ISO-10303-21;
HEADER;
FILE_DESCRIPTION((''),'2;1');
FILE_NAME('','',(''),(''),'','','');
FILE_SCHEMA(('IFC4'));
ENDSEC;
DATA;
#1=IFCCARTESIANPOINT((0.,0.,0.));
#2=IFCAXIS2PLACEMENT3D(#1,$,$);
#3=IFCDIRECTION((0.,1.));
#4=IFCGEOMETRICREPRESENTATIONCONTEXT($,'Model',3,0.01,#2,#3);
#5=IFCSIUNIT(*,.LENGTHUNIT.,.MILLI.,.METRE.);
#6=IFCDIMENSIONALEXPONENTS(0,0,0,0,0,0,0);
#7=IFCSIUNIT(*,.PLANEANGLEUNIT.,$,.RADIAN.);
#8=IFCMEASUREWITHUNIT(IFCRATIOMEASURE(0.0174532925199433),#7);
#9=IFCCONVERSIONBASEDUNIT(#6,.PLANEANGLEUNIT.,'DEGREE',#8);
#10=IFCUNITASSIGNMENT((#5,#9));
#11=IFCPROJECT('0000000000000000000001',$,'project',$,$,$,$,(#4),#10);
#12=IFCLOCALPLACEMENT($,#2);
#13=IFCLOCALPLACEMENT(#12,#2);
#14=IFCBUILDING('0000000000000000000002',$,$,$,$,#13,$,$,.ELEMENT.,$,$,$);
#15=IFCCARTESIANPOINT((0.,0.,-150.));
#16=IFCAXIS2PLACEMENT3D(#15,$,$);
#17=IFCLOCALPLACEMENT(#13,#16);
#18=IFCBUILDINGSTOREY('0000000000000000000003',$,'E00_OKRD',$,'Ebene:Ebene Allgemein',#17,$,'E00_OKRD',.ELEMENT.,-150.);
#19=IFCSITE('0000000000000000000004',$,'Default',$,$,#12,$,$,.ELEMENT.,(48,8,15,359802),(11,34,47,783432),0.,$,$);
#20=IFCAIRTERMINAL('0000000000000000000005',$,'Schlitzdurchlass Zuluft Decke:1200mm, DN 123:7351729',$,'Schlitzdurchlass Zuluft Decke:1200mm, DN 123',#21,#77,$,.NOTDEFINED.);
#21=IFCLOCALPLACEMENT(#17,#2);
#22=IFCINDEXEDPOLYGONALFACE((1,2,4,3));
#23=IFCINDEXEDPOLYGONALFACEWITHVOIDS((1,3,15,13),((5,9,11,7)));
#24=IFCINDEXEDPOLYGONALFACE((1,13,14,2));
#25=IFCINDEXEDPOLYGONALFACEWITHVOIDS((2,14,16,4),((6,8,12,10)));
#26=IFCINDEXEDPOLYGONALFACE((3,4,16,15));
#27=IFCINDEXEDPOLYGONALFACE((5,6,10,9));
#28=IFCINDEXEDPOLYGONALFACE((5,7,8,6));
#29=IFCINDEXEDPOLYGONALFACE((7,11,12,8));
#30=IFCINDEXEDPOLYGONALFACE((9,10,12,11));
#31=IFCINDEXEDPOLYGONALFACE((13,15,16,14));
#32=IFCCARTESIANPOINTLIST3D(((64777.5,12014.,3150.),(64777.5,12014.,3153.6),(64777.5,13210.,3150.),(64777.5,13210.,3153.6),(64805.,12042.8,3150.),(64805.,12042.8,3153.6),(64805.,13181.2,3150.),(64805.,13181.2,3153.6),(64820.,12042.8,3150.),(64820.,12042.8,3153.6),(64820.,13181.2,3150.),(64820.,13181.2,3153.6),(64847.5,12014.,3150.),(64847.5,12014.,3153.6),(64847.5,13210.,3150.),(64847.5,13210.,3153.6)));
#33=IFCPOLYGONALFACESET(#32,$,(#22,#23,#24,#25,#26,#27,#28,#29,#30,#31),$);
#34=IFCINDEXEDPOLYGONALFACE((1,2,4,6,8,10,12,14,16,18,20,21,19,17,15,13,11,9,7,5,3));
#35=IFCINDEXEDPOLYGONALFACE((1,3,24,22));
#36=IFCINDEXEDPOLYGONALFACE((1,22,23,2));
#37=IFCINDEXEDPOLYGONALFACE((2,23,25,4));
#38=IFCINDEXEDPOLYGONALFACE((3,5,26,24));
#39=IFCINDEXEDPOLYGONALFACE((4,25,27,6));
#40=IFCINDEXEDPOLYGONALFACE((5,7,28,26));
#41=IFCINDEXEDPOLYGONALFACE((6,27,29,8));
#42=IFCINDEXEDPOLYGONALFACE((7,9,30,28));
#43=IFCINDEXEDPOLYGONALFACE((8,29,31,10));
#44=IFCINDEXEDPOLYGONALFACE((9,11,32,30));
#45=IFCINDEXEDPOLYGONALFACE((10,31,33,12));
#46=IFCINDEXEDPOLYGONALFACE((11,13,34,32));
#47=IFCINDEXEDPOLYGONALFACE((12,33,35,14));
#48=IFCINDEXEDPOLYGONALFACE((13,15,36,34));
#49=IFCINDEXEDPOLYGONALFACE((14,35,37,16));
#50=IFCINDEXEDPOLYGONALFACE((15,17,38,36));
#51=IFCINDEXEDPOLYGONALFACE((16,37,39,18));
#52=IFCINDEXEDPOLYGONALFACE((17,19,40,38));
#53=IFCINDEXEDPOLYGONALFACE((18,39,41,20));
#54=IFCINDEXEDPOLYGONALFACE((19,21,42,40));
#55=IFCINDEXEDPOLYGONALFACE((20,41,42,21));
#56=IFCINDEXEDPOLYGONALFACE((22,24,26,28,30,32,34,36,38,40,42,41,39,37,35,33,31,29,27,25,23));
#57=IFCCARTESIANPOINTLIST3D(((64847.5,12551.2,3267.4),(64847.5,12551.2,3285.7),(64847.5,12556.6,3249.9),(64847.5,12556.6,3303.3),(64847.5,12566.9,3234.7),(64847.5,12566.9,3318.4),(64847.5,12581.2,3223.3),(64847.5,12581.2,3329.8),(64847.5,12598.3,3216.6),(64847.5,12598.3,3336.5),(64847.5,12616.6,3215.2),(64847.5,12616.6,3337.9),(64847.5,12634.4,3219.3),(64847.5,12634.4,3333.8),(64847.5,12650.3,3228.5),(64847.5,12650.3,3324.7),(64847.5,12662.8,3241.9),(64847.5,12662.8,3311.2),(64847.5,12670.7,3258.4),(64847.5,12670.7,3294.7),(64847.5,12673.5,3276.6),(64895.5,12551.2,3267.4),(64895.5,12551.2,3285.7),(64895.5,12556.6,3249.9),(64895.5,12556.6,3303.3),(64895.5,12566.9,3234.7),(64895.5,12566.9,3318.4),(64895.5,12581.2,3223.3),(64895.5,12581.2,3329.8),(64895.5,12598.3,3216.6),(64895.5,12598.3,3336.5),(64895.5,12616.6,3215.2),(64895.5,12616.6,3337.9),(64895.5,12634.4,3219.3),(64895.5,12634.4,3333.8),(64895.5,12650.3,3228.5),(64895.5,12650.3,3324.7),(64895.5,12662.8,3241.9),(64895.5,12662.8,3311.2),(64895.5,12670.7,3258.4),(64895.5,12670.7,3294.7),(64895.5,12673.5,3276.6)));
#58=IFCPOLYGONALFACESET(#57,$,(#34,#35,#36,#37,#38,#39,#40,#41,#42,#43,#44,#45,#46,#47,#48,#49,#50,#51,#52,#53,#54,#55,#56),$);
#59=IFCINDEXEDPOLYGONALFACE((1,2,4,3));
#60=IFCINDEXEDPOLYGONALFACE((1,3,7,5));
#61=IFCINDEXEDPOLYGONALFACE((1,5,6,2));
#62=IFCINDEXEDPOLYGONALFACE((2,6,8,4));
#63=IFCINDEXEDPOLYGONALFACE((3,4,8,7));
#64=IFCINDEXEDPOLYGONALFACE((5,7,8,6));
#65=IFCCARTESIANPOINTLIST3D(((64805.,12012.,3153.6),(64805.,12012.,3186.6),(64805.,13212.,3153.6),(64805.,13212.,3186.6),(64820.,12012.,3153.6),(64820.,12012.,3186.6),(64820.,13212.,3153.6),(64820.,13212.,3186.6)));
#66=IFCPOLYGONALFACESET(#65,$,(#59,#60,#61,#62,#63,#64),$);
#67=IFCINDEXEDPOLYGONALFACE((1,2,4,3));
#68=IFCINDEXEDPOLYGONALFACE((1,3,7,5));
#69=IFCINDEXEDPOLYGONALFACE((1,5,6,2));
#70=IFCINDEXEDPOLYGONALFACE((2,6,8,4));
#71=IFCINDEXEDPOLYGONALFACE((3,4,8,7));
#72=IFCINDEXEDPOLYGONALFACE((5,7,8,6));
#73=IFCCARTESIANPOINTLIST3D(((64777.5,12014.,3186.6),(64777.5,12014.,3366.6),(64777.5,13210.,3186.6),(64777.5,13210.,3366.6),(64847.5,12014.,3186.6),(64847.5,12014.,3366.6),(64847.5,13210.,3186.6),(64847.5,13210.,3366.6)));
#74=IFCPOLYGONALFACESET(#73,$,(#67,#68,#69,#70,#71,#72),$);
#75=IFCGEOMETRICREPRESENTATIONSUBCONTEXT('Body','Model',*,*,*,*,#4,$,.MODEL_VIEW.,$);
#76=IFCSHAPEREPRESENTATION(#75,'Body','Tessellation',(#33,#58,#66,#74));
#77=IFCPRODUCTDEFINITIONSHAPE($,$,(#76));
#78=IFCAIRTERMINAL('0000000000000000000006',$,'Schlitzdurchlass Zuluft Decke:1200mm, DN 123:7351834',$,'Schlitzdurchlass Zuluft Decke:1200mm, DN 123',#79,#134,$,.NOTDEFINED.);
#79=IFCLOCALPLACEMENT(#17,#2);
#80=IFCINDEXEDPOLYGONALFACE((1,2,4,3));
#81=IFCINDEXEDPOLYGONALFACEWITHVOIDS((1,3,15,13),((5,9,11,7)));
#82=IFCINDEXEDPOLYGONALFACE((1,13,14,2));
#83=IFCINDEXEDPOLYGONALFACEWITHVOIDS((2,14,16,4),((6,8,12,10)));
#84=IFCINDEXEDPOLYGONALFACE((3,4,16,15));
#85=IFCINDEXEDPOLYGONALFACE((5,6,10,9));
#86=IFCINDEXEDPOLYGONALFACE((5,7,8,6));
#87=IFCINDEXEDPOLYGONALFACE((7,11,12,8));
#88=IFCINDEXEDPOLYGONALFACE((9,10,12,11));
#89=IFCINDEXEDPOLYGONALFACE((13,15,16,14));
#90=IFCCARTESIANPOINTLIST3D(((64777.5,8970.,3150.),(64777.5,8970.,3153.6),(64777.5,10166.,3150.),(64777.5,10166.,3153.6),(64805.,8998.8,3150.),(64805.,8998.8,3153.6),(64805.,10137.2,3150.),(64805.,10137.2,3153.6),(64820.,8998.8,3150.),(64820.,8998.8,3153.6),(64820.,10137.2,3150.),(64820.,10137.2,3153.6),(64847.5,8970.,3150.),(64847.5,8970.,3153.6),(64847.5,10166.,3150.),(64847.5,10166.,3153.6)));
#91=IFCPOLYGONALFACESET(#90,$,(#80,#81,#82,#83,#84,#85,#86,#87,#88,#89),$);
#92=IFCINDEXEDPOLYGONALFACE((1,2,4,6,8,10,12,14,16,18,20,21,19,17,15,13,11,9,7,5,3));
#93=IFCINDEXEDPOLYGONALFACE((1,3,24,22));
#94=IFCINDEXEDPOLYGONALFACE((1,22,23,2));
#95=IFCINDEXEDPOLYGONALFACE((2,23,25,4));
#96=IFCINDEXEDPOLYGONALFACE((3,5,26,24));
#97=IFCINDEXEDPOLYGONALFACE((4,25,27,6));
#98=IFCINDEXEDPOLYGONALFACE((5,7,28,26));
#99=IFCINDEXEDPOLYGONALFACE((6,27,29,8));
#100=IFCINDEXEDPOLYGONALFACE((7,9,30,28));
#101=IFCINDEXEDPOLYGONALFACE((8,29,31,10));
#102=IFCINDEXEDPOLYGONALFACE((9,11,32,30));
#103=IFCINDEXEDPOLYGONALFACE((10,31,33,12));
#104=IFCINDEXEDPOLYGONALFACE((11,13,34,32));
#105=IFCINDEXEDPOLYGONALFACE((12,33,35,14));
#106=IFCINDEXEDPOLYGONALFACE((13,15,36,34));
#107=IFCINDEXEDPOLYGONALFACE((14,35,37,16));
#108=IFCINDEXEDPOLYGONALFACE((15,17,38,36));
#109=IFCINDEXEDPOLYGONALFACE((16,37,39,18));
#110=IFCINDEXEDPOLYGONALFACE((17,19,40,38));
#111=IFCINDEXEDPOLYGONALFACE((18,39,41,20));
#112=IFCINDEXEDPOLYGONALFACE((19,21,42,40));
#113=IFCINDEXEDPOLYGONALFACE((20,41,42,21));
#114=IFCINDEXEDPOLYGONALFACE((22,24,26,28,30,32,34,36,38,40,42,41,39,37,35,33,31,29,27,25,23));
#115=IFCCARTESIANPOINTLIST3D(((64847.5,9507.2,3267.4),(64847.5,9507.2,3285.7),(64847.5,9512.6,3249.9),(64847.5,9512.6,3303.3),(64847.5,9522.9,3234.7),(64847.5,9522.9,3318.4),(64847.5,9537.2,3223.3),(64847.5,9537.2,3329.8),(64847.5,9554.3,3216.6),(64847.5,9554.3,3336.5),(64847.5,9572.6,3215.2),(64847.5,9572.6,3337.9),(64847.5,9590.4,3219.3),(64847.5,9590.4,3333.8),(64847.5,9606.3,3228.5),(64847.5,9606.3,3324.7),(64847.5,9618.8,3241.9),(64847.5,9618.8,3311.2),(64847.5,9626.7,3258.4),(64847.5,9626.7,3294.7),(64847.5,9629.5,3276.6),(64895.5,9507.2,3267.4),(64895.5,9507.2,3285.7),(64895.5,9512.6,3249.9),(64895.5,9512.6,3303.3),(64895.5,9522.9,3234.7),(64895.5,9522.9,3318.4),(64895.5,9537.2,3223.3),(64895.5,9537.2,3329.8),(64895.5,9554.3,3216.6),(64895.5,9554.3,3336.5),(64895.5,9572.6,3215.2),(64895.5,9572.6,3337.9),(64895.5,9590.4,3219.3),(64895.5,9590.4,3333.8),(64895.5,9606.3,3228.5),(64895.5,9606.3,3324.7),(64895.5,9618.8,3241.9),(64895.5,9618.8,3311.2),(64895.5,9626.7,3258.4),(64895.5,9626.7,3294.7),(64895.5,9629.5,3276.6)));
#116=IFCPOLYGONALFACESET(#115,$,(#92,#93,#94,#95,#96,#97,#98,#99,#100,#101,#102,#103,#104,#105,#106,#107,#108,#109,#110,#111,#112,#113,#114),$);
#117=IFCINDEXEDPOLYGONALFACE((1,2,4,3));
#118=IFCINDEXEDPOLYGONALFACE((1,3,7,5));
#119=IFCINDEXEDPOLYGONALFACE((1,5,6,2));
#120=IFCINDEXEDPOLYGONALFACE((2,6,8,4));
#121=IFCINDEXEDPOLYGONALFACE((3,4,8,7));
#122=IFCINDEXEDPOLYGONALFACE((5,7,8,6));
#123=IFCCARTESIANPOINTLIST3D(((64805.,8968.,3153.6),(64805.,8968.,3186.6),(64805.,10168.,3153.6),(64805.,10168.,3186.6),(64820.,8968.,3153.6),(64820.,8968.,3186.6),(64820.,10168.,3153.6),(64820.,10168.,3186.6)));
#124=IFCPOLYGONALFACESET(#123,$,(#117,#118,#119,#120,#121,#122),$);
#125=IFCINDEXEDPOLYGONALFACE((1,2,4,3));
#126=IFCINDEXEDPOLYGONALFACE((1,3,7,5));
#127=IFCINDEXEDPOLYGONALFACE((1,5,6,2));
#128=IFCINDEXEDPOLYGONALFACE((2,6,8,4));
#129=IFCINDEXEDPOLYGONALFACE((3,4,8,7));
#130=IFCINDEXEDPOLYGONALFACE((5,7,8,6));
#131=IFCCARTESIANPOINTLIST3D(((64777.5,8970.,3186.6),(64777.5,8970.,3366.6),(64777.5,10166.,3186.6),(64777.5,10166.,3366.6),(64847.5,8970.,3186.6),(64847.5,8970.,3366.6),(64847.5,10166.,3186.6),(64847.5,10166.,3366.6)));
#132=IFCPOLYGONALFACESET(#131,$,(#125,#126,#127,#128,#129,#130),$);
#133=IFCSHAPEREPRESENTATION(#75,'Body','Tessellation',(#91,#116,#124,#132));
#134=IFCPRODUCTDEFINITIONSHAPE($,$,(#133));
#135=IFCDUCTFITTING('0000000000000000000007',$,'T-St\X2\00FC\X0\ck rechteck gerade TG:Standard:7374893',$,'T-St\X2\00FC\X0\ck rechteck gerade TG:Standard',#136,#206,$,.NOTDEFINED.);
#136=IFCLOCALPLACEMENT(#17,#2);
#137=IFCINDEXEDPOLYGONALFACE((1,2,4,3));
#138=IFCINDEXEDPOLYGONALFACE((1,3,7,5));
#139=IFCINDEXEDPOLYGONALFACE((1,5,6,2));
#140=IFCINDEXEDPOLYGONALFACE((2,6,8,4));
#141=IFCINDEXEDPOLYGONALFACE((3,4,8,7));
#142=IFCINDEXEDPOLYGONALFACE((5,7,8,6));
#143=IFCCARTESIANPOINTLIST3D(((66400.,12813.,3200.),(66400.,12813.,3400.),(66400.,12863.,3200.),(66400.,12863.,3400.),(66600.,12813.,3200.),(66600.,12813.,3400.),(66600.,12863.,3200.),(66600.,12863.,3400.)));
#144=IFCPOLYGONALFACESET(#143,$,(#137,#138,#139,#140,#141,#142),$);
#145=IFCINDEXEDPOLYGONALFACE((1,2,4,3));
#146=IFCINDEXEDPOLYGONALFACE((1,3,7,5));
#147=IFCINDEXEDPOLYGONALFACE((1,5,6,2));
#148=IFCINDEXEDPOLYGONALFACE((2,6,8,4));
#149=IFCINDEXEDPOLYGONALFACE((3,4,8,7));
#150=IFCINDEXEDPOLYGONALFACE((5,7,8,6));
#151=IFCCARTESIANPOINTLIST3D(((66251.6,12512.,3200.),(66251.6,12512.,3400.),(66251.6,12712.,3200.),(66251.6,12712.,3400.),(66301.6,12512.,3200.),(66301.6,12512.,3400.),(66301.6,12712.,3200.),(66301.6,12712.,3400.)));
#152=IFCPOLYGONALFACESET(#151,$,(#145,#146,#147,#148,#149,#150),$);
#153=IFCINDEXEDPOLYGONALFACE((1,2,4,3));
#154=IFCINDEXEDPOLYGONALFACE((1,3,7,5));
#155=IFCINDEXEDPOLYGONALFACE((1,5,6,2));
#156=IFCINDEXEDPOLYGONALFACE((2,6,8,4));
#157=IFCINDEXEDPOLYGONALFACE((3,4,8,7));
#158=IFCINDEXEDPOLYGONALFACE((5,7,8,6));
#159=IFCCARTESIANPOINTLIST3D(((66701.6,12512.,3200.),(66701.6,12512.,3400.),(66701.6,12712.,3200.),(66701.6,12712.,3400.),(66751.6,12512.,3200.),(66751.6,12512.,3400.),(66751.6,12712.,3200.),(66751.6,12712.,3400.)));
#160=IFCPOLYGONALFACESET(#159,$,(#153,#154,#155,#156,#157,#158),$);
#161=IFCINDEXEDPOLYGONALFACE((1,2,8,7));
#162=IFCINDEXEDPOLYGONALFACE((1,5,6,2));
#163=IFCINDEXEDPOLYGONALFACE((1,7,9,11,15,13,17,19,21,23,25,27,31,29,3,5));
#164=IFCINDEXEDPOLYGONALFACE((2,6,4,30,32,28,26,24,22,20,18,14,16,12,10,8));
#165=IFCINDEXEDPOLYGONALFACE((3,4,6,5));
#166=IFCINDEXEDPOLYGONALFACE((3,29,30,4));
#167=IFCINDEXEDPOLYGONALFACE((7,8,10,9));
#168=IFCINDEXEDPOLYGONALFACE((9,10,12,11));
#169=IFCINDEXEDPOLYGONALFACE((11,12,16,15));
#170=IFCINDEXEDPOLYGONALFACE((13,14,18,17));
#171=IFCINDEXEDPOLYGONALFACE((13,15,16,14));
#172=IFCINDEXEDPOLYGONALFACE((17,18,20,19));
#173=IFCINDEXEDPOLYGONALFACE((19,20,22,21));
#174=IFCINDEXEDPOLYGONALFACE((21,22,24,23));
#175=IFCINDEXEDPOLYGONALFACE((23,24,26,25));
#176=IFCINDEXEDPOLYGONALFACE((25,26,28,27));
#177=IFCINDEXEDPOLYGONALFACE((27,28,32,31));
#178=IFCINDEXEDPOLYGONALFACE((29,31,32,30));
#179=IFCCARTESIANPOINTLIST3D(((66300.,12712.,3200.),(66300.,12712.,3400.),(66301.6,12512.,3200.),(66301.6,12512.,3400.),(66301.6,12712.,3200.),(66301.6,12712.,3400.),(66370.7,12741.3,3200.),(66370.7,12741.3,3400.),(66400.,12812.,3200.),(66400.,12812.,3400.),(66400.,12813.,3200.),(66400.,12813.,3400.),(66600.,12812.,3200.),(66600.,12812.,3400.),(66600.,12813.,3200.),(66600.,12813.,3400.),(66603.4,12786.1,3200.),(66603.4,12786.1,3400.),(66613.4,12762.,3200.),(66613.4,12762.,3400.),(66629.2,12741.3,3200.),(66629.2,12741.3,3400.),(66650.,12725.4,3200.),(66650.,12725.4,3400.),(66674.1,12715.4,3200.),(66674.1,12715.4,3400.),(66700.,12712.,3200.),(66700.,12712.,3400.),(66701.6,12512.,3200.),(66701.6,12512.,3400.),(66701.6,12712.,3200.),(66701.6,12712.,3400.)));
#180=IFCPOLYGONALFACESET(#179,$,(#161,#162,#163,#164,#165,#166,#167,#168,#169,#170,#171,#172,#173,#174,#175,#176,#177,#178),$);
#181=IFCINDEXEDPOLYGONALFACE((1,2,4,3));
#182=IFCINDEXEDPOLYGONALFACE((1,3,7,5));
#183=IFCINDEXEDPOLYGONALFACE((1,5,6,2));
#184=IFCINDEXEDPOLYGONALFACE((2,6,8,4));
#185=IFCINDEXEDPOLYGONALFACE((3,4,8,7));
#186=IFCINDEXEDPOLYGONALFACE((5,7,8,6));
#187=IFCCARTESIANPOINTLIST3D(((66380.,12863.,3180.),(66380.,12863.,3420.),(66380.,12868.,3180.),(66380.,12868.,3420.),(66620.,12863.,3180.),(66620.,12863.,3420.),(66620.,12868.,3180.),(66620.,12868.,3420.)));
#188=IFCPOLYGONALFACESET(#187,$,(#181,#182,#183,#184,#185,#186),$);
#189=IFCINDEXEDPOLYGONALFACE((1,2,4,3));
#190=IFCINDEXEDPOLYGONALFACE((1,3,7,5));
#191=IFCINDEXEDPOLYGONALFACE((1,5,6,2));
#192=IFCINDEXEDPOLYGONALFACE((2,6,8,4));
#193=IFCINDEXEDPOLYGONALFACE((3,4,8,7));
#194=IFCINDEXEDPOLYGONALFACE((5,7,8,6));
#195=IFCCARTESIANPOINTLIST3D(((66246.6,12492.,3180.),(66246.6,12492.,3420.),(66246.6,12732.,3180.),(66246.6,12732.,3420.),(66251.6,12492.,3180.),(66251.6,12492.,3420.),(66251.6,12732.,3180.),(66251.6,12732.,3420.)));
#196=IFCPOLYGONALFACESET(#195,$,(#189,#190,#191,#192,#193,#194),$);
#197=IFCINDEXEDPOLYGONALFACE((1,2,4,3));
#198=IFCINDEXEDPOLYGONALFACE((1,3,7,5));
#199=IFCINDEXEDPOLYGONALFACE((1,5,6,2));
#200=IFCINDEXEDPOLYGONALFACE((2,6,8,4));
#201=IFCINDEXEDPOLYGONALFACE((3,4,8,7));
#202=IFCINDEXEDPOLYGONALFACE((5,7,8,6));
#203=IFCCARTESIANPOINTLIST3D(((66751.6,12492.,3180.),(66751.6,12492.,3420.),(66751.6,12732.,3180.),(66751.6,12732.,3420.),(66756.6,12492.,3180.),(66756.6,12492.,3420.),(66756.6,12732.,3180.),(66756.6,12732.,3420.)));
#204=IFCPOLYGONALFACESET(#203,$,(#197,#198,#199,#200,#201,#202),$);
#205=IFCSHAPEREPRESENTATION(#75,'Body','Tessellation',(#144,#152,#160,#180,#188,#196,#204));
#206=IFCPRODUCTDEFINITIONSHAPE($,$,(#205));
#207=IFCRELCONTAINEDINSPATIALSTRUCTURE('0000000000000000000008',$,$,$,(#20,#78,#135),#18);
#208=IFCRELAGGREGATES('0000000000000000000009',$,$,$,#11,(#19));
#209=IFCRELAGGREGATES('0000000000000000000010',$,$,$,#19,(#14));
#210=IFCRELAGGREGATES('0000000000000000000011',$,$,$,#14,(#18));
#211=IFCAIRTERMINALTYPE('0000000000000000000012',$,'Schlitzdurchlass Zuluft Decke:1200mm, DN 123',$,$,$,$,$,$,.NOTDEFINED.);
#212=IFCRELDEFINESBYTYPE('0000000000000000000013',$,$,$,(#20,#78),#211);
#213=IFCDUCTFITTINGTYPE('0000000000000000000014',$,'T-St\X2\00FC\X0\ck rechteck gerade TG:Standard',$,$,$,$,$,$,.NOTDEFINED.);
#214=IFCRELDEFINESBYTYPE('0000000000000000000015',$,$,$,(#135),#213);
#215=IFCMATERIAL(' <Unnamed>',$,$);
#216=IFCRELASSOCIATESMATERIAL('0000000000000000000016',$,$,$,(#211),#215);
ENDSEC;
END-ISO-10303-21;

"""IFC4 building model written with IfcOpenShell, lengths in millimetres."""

from ifc_helpers import new_model, entity, si_unit, converted_unit, direction, frame, frame_2d, origin, origin_2d_with_axis, place, context, subcontext, project, spatial, polyline, circle_curve, parameter, trimmed, segment, composite_curve, rectangle, circle, outline, extrude, source, transform, mapped, material, type_object, type_shapes, element, save


model = new_model("IFC4")

# Units and contexts
model_context = context("Model", 3, precision=0.01, world=origin(), true_north=direction((0.0, 1.0)))
body_context = subcontext(model_context, "Body", "Model", "MODEL_VIEW")
ifc_project = project(units=[si_unit("LENGTHUNIT", "METRE", prefix="MILLI"), converted_unit("PLANEANGLEUNIT", "DEGREE", entity("IfcRatioMeasure", 0.0174532925199433), si_unit("PLANEANGLEUNIT", "RADIAN"), dimensions=[0, 0, 0, 0, 0, 0, 0])], contexts=[model_context])

# Site, building, storey
site_placement = place(None, origin())
site = spatial("IfcSite", under=ifc_project, at=site_placement, Name="Default", CompositionType="ELEMENT", RefLatitude=(48, 8, 15, 359802), RefLongitude=(11, 34, 47, 783432), RefElevation=0.0)
building_placement = place(site_placement, origin())
building = spatial("IfcBuilding", under=site, at=building_placement, CompositionType="ELEMENT")
storey_placement = place(building_placement, frame((0.0, 0.0, -150.0)))
storey = spatial("IfcBuildingStorey", under=building, at=storey_placement, Name="E00_OKRD", ObjectType="Ebene:Ebene Allgemein", LongName="E00_OKRD", CompositionType="ELEMENT", Elevation=-150.0)

# Air terminals
ifc_material_1 = material(Name=" <Unnamed>")
air_terminal_type = type_object("IfcAirTerminalType", Name="Schlitzdurchlass Zuluft Decke:1200mm, DN 123", PredefinedType="NOTDEFINED", material=ifc_material_1)
shared_shape_1 = source(origin(), body_context, "Body", "SweptSolid", [
    extrude(outline(polyline([(-598.0, -35.0), (598.0, -35.0), (598.0, 35.0), (-598.0, 35.0), (-598.0, -35.0)]), holes=[polyline([(-569.2, -7.5), (-569.2, 7.5), (569.2, 7.5), (569.2, -7.5), (-569.2, -7.5)])]), frame((600.0, 35.0, 0.0), z_axis=(0.0, 0.0, 1.0), x_axis=(-1.0, 0.0, 0.0)), (0.0, 0.0, 1.0), 3.6),
    extrude(circle(Radius=61.5, at=frame_2d((0.0, 0.0), x_axis=(1.0, 0.0))), frame((600.0, 70.0, 126.6), z_axis=(0.0, 1.0, 0.0), x_axis=(-1.0, 0.0, 0.0)), (0.0, 0.0, 1.0), 48.0),
    extrude(rectangle(XDim=1200.0, YDim=15.0, at=origin_2d_with_axis()), frame((600.0, 35.0, 3.6), z_axis=(0.0, 0.0, 1.0), x_axis=(-1.0, 0.0, 0.0)), (0.0, 0.0, 1.0), 33.0),
    extrude(rectangle(XDim=1196.0, YDim=70.0, at=origin_2d_with_axis()), frame((600.0, 35.0, 36.6), z_axis=(0.0, 0.0, 1.0), x_axis=(-1.0, 0.0, 0.0)), (0.0, 0.0, 1.0), 180.0),
])
type_shapes(air_terminal_type, [shared_shape_1])
for number, where, z_axis, x_axis, name in (
    (1, (64777.5, 13212.0, 3150.0), (0.0, 0.0, 1.0), (0.0, -1.0, 0.0), "Schlitzdurchlass Zuluft Decke:1200mm, DN 123:7351729"),
    (2, (64777.5, 10168.0, 3150.0), (0.0, 0.0, 1.0), (0.0, -1.0, 0.0), "Schlitzdurchlass Zuluft Decke:1200mm, DN 123:7351834"),
):
    element("IfcAirTerminal", number, at=place(storey_placement, frame(where, z_axis=z_axis, x_axis=x_axis)), inside=storey, type_object=air_terminal_type, Name=name, ObjectType="Schlitzdurchlass Zuluft Decke:1200mm, DN 123", PredefinedType="NOTDEFINED", context=body_context, shape_type="MappedRepresentation", body=[
        mapped(shared_shape_1, transform((0.0, 0.0, 0.0), scale=1.0)),
    ])

# Duct fitting
duct_fitting_type_1 = type_object("IfcDuctFittingType", Name="T-Stück rechteck gerade TG:Standard", PredefinedType="NOTDEFINED")
shared_shape_2 = source(origin(), body_context, "Body", "SweptSolid", [
    extrude(rectangle(XDim=50.0, YDim=200.0, at=frame_2d((0.0, 0.0), x_axis=(1.0, 0.0))), frame((0.0, -226.0, -100.0), z_axis=(0.0, 0.0, 1.0), x_axis=(0.0, -1.0, 0.0)), (0.0, 0.0, 1.0), 200.0),
    extrude(rectangle(XDim=50.0, YDim=200.0, at=frame_2d((0.0, 0.0), x_axis=(1.0, 0.0))), frame((223.4, 0.0, -100.0), z_axis=(0.0, 0.0, 1.0), x_axis=(-1.0, 0.0, 0.0)), (0.0, 0.0, 1.0), 200.0),
    extrude(rectangle(XDim=50.0, YDim=200.0, at=frame_2d((0.0, 0.0), x_axis=(1.0, 0.0))), frame((-226.6, 0.0, -100.0)), (0.0, 0.0, 1.0), 200.0),
    extrude(outline(composite_curve([segment(trimmed(circle_curve(frame_2d((-200.6, -99.8), x_axis=(-1.0, 0.0)), 100.0), [parameter(180.0)], [parameter(270.0)], True, "PARAMETER"), False, "CONTINUOUS"), segment(polyline([(-100.6, -99.8), (-100.6, -100.8)]), True, "CONTINUOUS"), segment(polyline([(-100.6, -100.8), (99.4, -100.8)]), True, "CONTINUOUS"), segment(polyline([(99.4, -100.8), (99.4, -99.8)]), True, "CONTINUOUS"), segment(trimmed(circle_curve(frame_2d((199.4, -99.8), x_axis=(-1.0, 0.0)), 100.0), [parameter(270.0)], [parameter(0.0)], True, "PARAMETER"), False, "CONTINUOUS"), segment(polyline([(199.4, 0.2), (201.0, 0.2)]), True, "CONTINUOUS"), segment(polyline([(201.0, 0.2), (201.0, 200.2)]), True, "CONTINUOUS"), segment(polyline([(201.0, 200.2), (-199.0, 200.2)]), True, "CONTINUOUS"), segment(polyline([(-199.0, 200.2), (-199.0, 0.2)]), True, "CONTINUOUS"), segment(polyline([(-199.0, 0.2), (-200.6, 0.2)]), True, "CONTINUOUS")], self_intersect=False)), frame((-0.6, -100.2, -100.0), z_axis=(0.0, 0.0, -1.0), x_axis=(-1.0, 0.0, 0.0)), (0.0, 0.0, -1.0), 200.0),
    extrude(rectangle(XDim=5.0, YDim=240.0, at=frame_2d((0.0, 0.0), x_axis=(1.0, 0.0))), frame((0.0, -253.5, -120.0), z_axis=(0.0, 0.0, 1.0), x_axis=(0.0, 1.0, 0.0)), (0.0, 0.0, 1.0), 240.0),
    extrude(rectangle(XDim=5.0, YDim=240.0, at=origin_2d_with_axis()), frame((250.9, 0.0, -120.0), z_axis=(0.0, 0.0, 1.0), x_axis=(-1.0, 0.0, 0.0)), (0.0, 0.0, 1.0), 240.0),
    extrude(rectangle(XDim=5.0, YDim=240.0, at=origin_2d_with_axis()), frame((-254.1, 0.0, -120.0), z_axis=(0.0, 0.0, 1.0), x_axis=(-1.0, 0.0, 0.0)), (0.0, 0.0, 1.0), 240.0),
])
type_shapes(duct_fitting_type_1, [shared_shape_2])
duct_fitting_1_placement = place(storey_placement, frame((66500.0, 12612.0, 3300.0), z_axis=(0.0, 0.0, 1.0), x_axis=(-1.0, 0.0, 0.0)))
element("IfcDuctFitting", 3, at=duct_fitting_1_placement, inside=storey, type_object=duct_fitting_type_1, Name="T-Stück rechteck gerade TG:Standard:7374893", ObjectType="T-Stück rechteck gerade TG:Standard", PredefinedType="NOTDEFINED", context=body_context, shape_type="MappedRepresentation", body=[
    mapped(shared_shape_2, transform((0.0, 0.0, 0.0), scale=1.0)),
])

save(model, "model.ifc")
